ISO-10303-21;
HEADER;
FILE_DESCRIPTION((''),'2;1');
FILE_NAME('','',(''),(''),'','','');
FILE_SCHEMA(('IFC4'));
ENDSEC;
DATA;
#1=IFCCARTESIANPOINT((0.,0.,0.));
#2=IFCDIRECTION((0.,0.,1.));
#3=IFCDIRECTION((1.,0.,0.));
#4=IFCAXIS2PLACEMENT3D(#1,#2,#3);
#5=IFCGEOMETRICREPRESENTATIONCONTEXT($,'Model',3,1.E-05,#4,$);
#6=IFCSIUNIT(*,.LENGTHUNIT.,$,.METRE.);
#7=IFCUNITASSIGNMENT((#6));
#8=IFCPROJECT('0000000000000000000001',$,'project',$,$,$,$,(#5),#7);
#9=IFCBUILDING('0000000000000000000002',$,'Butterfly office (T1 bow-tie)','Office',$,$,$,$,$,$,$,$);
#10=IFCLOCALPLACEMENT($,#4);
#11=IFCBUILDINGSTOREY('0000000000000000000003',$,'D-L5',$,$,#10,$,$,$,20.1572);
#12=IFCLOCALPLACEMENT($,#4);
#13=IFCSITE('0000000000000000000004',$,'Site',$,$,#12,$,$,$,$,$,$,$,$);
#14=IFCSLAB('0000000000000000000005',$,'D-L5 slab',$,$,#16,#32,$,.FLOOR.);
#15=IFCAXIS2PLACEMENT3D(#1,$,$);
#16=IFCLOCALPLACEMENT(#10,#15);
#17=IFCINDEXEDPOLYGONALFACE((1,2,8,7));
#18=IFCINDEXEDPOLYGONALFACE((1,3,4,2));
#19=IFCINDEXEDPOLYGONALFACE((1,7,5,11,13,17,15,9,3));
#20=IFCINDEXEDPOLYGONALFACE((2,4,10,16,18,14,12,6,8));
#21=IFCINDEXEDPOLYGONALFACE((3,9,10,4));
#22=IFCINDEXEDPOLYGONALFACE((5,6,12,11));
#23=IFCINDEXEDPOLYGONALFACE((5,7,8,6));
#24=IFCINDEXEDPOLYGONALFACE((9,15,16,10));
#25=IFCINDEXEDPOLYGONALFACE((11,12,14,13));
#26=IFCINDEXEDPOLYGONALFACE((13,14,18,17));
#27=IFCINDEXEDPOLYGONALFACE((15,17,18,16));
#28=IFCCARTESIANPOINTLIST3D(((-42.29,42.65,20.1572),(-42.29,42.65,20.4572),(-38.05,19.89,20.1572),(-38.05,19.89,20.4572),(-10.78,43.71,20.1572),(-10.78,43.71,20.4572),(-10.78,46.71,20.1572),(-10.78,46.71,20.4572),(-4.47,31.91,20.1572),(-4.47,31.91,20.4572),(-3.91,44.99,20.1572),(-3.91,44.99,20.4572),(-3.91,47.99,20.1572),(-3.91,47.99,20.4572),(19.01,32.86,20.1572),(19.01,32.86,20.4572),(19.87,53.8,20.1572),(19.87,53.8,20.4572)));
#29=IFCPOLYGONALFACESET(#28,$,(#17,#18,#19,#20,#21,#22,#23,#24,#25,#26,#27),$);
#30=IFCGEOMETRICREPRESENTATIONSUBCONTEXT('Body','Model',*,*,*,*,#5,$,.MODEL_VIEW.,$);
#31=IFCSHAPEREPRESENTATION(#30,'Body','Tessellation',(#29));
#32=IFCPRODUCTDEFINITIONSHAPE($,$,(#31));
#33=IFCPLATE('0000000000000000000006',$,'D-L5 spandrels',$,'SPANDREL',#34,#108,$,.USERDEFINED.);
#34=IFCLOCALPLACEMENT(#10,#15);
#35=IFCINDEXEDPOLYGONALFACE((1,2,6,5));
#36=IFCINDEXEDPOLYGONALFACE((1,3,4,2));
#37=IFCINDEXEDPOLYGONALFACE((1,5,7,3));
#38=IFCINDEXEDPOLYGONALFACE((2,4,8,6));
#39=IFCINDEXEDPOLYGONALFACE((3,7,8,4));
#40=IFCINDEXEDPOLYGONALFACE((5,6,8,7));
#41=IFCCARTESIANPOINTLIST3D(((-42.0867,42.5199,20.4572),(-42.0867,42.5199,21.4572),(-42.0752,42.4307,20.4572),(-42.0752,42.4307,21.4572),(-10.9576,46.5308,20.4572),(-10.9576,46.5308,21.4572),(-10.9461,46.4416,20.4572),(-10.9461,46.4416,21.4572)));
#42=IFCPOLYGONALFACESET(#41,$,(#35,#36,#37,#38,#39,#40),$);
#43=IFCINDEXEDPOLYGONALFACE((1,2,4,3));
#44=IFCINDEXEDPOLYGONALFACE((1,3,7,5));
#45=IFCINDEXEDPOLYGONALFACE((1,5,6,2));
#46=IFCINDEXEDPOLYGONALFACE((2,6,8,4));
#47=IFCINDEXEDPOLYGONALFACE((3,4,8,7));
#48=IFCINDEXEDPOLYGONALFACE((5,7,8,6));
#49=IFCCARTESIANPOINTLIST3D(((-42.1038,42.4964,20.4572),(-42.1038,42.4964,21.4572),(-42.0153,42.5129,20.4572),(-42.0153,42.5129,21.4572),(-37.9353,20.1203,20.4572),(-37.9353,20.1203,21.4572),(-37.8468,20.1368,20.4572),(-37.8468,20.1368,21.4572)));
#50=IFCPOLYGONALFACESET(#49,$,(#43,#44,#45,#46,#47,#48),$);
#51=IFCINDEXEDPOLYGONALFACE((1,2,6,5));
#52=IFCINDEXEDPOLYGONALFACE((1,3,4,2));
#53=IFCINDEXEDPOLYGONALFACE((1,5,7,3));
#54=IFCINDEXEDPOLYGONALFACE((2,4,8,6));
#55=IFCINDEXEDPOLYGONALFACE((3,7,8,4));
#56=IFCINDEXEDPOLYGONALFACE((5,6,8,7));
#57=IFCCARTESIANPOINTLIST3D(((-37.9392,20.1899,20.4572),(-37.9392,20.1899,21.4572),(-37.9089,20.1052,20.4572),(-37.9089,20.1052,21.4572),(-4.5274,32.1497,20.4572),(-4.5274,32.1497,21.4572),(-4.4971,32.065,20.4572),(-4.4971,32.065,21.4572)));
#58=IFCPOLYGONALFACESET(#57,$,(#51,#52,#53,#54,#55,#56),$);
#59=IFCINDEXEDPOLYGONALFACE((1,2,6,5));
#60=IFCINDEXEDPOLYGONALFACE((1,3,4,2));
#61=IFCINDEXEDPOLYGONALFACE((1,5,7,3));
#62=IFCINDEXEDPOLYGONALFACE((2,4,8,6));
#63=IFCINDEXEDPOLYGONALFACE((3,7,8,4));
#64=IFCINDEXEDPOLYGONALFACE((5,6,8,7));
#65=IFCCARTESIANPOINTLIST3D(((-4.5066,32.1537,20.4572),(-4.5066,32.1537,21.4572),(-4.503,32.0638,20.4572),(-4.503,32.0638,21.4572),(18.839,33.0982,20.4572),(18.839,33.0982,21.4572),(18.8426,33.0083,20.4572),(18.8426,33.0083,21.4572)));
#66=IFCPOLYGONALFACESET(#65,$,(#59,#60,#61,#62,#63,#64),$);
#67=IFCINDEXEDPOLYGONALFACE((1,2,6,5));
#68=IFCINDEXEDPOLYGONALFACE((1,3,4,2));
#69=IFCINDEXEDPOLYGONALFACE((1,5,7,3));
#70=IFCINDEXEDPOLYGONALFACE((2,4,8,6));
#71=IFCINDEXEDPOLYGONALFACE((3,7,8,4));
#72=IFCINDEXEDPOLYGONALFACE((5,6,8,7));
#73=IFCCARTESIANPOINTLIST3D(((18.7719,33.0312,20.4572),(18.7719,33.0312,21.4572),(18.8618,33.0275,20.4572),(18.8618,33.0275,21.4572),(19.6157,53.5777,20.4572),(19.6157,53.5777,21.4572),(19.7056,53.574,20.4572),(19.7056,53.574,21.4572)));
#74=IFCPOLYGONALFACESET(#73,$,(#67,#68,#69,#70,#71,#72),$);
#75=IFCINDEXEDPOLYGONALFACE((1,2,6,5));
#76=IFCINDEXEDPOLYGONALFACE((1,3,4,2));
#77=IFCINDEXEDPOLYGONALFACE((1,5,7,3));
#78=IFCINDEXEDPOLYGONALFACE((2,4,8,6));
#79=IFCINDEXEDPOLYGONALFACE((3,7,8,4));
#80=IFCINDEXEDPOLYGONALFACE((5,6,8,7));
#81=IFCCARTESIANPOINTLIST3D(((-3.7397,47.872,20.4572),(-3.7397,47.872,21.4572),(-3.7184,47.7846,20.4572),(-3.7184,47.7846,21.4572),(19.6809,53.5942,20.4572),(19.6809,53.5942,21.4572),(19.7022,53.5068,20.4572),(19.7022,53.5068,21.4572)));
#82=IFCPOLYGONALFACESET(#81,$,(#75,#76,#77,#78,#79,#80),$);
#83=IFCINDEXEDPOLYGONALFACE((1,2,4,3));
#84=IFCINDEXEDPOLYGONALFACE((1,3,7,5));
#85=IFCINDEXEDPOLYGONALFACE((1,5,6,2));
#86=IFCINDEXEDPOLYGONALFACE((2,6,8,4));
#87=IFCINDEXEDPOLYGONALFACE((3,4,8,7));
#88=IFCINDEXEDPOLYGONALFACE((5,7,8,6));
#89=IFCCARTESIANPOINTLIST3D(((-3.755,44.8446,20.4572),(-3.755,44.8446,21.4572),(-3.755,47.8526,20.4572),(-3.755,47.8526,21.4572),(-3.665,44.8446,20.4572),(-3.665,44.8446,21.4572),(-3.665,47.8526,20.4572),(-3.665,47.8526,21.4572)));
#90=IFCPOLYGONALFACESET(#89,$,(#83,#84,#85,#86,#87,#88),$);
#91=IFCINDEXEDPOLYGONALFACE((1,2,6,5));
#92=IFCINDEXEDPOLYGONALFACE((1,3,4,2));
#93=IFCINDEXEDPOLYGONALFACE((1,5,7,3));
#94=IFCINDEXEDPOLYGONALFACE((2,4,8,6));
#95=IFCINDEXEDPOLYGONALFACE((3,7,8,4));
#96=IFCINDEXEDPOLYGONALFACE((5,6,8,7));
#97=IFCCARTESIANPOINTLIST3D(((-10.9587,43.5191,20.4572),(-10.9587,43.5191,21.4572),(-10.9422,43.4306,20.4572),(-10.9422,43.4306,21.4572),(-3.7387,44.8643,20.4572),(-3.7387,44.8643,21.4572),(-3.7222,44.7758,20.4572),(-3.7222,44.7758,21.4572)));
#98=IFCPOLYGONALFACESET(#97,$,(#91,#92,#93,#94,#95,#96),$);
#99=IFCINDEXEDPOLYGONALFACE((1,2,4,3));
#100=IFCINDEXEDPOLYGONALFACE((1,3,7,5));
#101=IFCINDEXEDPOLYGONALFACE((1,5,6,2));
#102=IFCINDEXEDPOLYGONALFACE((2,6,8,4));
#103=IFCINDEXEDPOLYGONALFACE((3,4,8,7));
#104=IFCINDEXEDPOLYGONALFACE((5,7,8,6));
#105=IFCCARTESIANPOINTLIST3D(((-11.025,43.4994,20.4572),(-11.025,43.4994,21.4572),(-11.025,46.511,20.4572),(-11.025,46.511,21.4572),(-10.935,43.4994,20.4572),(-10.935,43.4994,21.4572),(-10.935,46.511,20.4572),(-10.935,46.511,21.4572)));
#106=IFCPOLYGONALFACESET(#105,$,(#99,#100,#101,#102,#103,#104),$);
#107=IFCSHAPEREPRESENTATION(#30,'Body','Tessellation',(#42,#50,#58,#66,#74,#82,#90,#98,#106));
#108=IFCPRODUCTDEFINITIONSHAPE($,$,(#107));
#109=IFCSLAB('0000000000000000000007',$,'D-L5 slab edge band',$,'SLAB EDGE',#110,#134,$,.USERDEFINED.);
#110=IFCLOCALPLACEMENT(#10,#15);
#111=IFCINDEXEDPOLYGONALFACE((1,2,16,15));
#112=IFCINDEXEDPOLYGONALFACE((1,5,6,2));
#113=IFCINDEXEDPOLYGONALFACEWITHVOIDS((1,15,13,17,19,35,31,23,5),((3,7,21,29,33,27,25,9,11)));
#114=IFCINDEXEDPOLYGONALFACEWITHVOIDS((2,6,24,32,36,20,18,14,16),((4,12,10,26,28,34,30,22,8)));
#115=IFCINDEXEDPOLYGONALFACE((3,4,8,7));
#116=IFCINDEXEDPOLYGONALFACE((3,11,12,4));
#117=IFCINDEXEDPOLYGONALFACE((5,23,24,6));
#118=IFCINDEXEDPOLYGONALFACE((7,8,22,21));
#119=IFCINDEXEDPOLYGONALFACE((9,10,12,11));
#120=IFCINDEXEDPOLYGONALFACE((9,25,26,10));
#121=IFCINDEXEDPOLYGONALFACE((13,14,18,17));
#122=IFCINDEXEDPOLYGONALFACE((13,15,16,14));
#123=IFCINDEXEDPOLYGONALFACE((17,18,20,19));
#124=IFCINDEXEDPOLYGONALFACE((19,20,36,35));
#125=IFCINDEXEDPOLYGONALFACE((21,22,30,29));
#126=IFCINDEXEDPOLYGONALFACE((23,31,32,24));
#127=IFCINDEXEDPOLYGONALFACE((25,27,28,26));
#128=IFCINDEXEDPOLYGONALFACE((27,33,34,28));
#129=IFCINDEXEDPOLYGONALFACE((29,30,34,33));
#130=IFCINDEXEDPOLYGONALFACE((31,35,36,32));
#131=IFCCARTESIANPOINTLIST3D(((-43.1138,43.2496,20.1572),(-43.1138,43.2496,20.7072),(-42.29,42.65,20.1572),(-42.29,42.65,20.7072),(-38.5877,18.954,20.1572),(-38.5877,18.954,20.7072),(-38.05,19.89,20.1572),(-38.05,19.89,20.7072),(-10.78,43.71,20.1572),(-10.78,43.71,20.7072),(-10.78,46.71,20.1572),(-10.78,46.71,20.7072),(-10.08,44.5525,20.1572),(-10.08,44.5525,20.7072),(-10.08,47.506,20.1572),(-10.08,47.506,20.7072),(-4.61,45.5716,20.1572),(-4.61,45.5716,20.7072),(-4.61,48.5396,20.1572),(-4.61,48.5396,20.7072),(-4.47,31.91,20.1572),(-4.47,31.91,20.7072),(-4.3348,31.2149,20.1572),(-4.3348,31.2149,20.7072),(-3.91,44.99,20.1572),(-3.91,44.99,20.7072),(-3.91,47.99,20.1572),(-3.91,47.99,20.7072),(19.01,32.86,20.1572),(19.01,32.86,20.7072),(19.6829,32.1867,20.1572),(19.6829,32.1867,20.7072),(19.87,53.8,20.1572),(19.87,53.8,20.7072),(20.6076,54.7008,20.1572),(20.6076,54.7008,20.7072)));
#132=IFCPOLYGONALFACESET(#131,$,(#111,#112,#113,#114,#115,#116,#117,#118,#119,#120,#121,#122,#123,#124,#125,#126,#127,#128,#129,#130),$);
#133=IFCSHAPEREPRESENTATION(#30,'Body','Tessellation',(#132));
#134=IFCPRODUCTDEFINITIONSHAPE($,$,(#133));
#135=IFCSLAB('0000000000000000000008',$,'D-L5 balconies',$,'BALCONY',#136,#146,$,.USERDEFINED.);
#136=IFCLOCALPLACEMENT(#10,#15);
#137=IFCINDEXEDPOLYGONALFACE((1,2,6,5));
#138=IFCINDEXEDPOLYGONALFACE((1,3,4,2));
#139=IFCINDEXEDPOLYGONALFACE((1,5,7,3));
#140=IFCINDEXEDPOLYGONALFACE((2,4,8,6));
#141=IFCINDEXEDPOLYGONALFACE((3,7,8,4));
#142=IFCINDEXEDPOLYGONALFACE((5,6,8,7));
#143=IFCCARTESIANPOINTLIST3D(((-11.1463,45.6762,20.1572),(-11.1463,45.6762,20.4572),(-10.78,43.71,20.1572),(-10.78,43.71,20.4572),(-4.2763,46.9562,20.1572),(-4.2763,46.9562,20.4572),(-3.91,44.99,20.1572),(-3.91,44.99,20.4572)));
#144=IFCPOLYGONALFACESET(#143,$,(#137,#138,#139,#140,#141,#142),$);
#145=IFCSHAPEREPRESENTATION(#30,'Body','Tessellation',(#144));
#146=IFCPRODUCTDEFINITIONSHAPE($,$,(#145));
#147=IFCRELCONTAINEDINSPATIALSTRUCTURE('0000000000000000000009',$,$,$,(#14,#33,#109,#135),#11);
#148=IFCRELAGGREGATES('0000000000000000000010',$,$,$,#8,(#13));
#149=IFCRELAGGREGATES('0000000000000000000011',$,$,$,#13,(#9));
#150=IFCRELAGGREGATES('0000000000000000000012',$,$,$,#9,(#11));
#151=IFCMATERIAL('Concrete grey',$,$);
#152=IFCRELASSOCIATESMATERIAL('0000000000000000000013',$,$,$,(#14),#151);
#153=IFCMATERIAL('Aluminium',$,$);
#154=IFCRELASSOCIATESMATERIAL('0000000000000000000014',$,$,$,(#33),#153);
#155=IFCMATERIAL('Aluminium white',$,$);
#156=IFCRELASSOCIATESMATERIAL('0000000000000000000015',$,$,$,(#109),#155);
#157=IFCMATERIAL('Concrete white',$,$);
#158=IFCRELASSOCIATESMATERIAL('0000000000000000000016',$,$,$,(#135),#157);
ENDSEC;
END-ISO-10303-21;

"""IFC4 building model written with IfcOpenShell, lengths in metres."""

from ifc_helpers import new_model, si_unit, frame, origin_with_axes, place, context, subcontext, project, spatial, polyline, outline, extrude, material, element, save


model = new_model("IFC4")

# Units and contexts
model_context = context("Model", 3, precision=1e-05, world=origin_with_axes())
body_context = subcontext(model_context, "Body", "Model", "MODEL_VIEW")
ifc_project = project(units=[si_unit("LENGTHUNIT", "METRE")], contexts=[model_context])

# Site, building, storey
site_placement = place(None, origin_with_axes())
site = spatial("IfcSite", under=ifc_project, at=site_placement, Name="Site")
building = spatial("IfcBuilding", under=site, Name="Butterfly office (T1 bow-tie)", Description="Office")
storey_placement = place(None, origin_with_axes())
storey = spatial("IfcBuildingStorey", under=building, at=storey_placement, Name="D-L5", Elevation=20.1572)

# Shared definitions
ifc_material_1 = material(Name="Aluminium")

# Slab
ifc_material_2 = material(Name="Concrete grey")
slab_1_placement = place(storey_placement, origin_with_axes())
element("IfcSlab", 1, at=slab_1_placement, inside=storey, material=ifc_material_2, Name="D-L5 slab", PredefinedType="FLOOR", context=body_context, shape_type="SweptSolid", body=[
    extrude(outline(polyline([(-10.78, 46.71), (-42.29, 42.65), (-38.05, 19.89), (-4.47, 31.91), (19.01, 32.86), (19.87, 53.8), (-3.91, 47.99), (-3.91, 44.99), (-10.78, 43.71), (-10.78, 46.71)])), frame((0.0, 0.0, 20.1572), z_axis=(0.0, 0.0, 1.0), x_axis=(1.0, 0.0, 0.0)), (0.0, 0.0, 1.0), 0.3),
])

# Plate
plate_placement = place(storey_placement, origin_with_axes())
element("IfcPlate", 2, at=plate_placement, inside=storey, material=ifc_material_1, Name="D-L5 spandrels", ObjectType="SPANDREL", PredefinedType="USERDEFINED", context=body_context, shape_type="SweptSolid", body=[
    extrude(outline(polyline([(-10.9576, 46.5308), (-42.0867, 42.5199), (-42.0752, 42.4307), (-10.9461, 46.4416), (-10.9576, 46.5308)])), frame((0.0, 0.0, 20.4572), z_axis=(0.0, 0.0, 1.0), x_axis=(1.0, 0.0, 0.0)), (0.0, 0.0, 1.0), 1.0),
    extrude(outline(polyline([(-42.1038, 42.4964), (-37.9353, 20.1203), (-37.8468, 20.1368), (-42.0153, 42.5129), (-42.1038, 42.4964)])), frame((0.0, 0.0, 20.4572), z_axis=(0.0, 0.0, 1.0), x_axis=(1.0, 0.0, 0.0)), (0.0, 0.0, 1.0), 1.0),
    extrude(outline(polyline([(-37.9089, 20.1052), (-4.4971, 32.065), (-4.5274, 32.1497), (-37.9392, 20.1899), (-37.9089, 20.1052)])), frame((0.0, 0.0, 20.4572), z_axis=(0.0, 0.0, 1.0), x_axis=(1.0, 0.0, 0.0)), (0.0, 0.0, 1.0), 1.0),
    extrude(outline(polyline([(-4.503, 32.0638), (18.8426, 33.0083), (18.839, 33.0982), (-4.5066, 32.1537), (-4.503, 32.0638)])), frame((0.0, 0.0, 20.4572), z_axis=(0.0, 0.0, 1.0), x_axis=(1.0, 0.0, 0.0)), (0.0, 0.0, 1.0), 1.0),
    extrude(outline(polyline([(18.8618, 33.0275), (19.7056, 53.574), (19.6157, 53.5777), (18.7719, 33.0312), (18.8618, 33.0275)])), frame((0.0, 0.0, 20.4572), z_axis=(0.0, 0.0, 1.0), x_axis=(1.0, 0.0, 0.0)), (0.0, 0.0, 1.0), 1.0),
    extrude(outline(polyline([(19.6809, 53.5942), (-3.7397, 47.872), (-3.7184, 47.7846), (19.7022, 53.5068), (19.6809, 53.5942)])), frame((0.0, 0.0, 20.4572), z_axis=(0.0, 0.0, 1.0), x_axis=(1.0, 0.0, 0.0)), (0.0, 0.0, 1.0), 1.0),
    extrude(outline(polyline([(-3.755, 47.8526), (-3.755, 44.8446), (-3.665, 44.8446), (-3.665, 47.8526), (-3.755, 47.8526)])), frame((0.0, 0.0, 20.4572), z_axis=(0.0, 0.0, 1.0), x_axis=(1.0, 0.0, 0.0)), (0.0, 0.0, 1.0), 1.0),
    extrude(outline(polyline([(-3.7387, 44.8643), (-10.9587, 43.5191), (-10.9422, 43.4306), (-3.7222, 44.7758), (-3.7387, 44.8643)])), frame((0.0, 0.0, 20.4572), z_axis=(0.0, 0.0, 1.0), x_axis=(1.0, 0.0, 0.0)), (0.0, 0.0, 1.0), 1.0),
    extrude(outline(polyline([(-10.935, 43.4994), (-10.935, 46.511), (-11.025, 46.511), (-11.025, 43.4994), (-10.935, 43.4994)])), frame((0.0, 0.0, 20.4572), z_axis=(0.0, 0.0, 1.0), x_axis=(1.0, 0.0, 0.0)), (0.0, 0.0, 1.0), 1.0),
])

# Slabs
ifc_material_3 = material(Name="Aluminium white")
slab_2_placement = place(storey_placement, origin_with_axes())
element("IfcSlab", 3, at=slab_2_placement, inside=storey, material=ifc_material_3, Name="D-L5 slab edge band", ObjectType="SLAB EDGE", PredefinedType="USERDEFINED", context=body_context, shape_type="SweptSolid", body=[
    extrude(outline(polyline([(-10.08, 47.506), (-43.1138, 43.2496), (-38.5877, 18.954), (-4.3348, 31.2149), (19.6829, 32.1867), (20.6076, 54.7008), (-4.61, 48.5396), (-4.61, 45.5716), (-10.08, 44.5525), (-10.08, 47.506)]), holes=[polyline([(-10.78, 46.71), (-42.29, 42.65), (-38.05, 19.89), (-4.47, 31.91), (19.01, 32.86), (19.87, 53.8), (-3.91, 47.99), (-3.91, 44.99), (-10.78, 43.71), (-10.78, 46.71)])]), frame((0.0, 0.0, 20.1572), z_axis=(0.0, 0.0, 1.0), x_axis=(1.0, 0.0, 0.0)), (0.0, 0.0, 1.0), 0.55),
])
ifc_material_4 = material(Name="Concrete white")
slab_3_placement = place(storey_placement, origin_with_axes())
element("IfcSlab", 4, at=slab_3_placement, inside=storey, material=ifc_material_4, Name="D-L5 balconies", ObjectType="BALCONY", PredefinedType="USERDEFINED", context=body_context, shape_type="SweptSolid", body=[
    extrude(outline(polyline([(-3.91, 44.99), (-10.78, 43.71), (-11.1463, 45.6762), (-4.2763, 46.9562), (-3.91, 44.99)])), frame((0.0, 0.0, 20.1572), z_axis=(0.0, 0.0, 1.0), x_axis=(1.0, 0.0, 0.0)), (0.0, 0.0, 1.0), 0.3),
])

save(model, "model.ifc")
